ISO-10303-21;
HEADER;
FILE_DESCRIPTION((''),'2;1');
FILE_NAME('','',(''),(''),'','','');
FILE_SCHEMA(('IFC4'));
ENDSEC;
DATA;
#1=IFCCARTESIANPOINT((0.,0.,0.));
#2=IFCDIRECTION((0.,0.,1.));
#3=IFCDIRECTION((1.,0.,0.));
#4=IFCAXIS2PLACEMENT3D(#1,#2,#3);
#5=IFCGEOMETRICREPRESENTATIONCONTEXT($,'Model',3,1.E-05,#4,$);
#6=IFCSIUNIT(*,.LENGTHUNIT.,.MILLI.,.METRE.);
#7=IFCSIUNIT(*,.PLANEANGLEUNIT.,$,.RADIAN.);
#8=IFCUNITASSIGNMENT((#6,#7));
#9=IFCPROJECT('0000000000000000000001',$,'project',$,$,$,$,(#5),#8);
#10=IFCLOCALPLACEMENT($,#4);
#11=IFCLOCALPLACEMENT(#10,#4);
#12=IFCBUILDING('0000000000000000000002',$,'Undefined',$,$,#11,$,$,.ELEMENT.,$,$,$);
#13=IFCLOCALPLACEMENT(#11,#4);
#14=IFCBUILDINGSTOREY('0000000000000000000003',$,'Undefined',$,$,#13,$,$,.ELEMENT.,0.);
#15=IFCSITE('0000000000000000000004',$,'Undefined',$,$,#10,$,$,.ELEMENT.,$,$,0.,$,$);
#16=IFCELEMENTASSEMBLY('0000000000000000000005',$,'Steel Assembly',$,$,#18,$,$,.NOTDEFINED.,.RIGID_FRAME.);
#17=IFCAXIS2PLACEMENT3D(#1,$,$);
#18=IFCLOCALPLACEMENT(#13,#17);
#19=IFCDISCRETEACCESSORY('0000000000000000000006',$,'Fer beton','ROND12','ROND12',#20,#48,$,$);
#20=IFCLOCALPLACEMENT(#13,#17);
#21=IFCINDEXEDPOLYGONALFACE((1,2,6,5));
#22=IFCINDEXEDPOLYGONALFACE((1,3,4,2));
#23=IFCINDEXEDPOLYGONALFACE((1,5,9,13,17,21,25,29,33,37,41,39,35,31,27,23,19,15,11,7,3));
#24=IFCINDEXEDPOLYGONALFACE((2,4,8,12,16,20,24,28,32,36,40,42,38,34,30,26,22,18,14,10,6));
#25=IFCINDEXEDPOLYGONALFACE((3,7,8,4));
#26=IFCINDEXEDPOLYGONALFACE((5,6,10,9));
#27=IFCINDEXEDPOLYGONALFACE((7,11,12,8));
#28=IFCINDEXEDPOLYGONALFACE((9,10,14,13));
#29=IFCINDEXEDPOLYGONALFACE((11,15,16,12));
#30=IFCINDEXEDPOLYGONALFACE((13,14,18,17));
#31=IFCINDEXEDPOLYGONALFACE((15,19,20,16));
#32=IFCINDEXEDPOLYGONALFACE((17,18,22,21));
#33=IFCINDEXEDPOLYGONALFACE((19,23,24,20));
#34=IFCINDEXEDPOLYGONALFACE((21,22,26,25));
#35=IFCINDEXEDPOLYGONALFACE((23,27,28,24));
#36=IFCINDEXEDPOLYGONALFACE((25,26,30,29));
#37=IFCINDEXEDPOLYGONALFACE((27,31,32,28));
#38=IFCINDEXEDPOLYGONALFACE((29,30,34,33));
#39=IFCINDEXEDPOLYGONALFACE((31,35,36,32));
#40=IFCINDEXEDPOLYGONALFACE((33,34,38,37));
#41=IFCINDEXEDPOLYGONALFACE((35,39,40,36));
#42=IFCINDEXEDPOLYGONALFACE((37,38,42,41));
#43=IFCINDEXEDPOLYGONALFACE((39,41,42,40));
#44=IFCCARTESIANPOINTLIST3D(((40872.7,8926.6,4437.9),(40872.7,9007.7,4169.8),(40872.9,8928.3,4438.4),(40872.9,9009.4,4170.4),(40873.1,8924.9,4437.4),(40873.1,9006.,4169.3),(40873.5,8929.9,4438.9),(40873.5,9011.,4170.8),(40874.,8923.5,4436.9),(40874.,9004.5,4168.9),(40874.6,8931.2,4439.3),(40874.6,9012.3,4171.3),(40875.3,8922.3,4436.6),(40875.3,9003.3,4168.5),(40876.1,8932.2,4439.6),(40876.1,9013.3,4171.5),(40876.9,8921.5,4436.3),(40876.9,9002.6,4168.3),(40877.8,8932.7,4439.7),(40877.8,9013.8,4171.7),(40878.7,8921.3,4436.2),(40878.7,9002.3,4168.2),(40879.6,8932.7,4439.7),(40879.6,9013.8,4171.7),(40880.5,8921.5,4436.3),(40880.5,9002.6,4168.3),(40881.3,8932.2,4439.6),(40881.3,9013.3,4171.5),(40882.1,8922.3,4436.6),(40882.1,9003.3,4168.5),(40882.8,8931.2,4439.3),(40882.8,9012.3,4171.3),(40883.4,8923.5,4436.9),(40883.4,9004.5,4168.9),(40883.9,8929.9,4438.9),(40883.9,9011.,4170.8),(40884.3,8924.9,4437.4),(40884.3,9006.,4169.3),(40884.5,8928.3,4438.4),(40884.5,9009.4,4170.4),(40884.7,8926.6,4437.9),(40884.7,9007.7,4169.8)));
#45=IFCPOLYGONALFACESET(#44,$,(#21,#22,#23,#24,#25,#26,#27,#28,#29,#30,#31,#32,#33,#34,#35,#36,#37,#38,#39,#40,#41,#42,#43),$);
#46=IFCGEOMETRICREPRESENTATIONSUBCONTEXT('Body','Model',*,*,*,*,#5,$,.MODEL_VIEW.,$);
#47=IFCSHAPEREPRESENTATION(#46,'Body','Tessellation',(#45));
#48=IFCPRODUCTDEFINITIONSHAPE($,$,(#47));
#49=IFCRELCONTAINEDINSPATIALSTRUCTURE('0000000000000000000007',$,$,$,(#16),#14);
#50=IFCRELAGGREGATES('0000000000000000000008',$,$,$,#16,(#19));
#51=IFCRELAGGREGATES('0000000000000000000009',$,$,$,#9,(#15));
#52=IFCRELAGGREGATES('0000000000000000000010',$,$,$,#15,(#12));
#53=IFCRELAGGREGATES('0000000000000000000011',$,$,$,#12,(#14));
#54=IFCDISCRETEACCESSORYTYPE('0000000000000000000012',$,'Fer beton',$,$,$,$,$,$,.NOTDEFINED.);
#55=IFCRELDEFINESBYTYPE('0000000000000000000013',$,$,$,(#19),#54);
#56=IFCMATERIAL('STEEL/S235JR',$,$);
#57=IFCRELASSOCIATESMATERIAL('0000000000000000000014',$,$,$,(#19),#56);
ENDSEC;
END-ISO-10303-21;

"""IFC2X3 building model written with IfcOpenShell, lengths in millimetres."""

from ifc_helpers import new_model, si_unit, frame, origin_with_axes, origin_2d_with_axis, place, context, subcontext, project, spatial, circle, extrude, material, type_object, element, aggregate, save


model = new_model("IFC2X3")

# Units and contexts
model_context = context("Model", 3, precision=1e-05, world=origin_with_axes())
body_context = subcontext(model_context, "Body", "Model", "MODEL_VIEW")
ifc_project = project(units=[si_unit("LENGTHUNIT", "METRE", prefix="MILLI"), si_unit("PLANEANGLEUNIT", "RADIAN")], contexts=[model_context])

# Site, building, storey
site_placement = place(None, origin_with_axes())
site = spatial("IfcSite", under=ifc_project, at=site_placement, Name="Undefined", CompositionType="ELEMENT", RefElevation=0.0)
building_placement = place(site_placement, origin_with_axes())
building = spatial("IfcBuilding", under=site, at=building_placement, Name="Undefined", CompositionType="ELEMENT")
storey_placement = place(building_placement, origin_with_axes())
storey = spatial("IfcBuildingStorey", under=building, at=storey_placement, Name="Undefined", CompositionType="ELEMENT", Elevation=0.0)

# Element assembly
ifc_material_1 = material(Name="STEEL/S235JR")
assembly_1_placement = place(storey_placement, origin_with_axes())
assembly_1 = element("IfcElementAssembly", 1, at=assembly_1_placement, inside=storey, Name="Steel Assembly", AssemblyPlace="NOTDEFINED", PredefinedType="RIGID_FRAME")

# Discrete accessory
discrete_accessory_type_1 = type_object("IfcDiscreteAccessoryType", Name="Fer beton")
discrete_accessory_1_placement = place(assembly_1_placement, frame((40878.7, 8927.0, 4438.0), z_axis=(1.0, 0.0, 0.0), x_axis=(0.0, 0.289497, -0.957179)))
discrete_accessory_1 = element("IfcDiscreteAccessory", 2, at=discrete_accessory_1_placement, type_object=discrete_accessory_type_1, material=ifc_material_1, Name="Fer beton", Description="ROND12", ObjectType="ROND12", context=body_context, shape_type="SweptSolid", body=[
    extrude(circle(Radius=6.0, at=origin_2d_with_axis()), frame((280.0, 0.0, 0.0), z_axis=(-1.0, 0.0, 0.0), x_axis=(0.0, -1.0, 0.0)), (0.0, 0.0, 1.0), 280.0),
])
aggregate(assembly_1, [discrete_accessory_1])

save(model, "model.ifc")
